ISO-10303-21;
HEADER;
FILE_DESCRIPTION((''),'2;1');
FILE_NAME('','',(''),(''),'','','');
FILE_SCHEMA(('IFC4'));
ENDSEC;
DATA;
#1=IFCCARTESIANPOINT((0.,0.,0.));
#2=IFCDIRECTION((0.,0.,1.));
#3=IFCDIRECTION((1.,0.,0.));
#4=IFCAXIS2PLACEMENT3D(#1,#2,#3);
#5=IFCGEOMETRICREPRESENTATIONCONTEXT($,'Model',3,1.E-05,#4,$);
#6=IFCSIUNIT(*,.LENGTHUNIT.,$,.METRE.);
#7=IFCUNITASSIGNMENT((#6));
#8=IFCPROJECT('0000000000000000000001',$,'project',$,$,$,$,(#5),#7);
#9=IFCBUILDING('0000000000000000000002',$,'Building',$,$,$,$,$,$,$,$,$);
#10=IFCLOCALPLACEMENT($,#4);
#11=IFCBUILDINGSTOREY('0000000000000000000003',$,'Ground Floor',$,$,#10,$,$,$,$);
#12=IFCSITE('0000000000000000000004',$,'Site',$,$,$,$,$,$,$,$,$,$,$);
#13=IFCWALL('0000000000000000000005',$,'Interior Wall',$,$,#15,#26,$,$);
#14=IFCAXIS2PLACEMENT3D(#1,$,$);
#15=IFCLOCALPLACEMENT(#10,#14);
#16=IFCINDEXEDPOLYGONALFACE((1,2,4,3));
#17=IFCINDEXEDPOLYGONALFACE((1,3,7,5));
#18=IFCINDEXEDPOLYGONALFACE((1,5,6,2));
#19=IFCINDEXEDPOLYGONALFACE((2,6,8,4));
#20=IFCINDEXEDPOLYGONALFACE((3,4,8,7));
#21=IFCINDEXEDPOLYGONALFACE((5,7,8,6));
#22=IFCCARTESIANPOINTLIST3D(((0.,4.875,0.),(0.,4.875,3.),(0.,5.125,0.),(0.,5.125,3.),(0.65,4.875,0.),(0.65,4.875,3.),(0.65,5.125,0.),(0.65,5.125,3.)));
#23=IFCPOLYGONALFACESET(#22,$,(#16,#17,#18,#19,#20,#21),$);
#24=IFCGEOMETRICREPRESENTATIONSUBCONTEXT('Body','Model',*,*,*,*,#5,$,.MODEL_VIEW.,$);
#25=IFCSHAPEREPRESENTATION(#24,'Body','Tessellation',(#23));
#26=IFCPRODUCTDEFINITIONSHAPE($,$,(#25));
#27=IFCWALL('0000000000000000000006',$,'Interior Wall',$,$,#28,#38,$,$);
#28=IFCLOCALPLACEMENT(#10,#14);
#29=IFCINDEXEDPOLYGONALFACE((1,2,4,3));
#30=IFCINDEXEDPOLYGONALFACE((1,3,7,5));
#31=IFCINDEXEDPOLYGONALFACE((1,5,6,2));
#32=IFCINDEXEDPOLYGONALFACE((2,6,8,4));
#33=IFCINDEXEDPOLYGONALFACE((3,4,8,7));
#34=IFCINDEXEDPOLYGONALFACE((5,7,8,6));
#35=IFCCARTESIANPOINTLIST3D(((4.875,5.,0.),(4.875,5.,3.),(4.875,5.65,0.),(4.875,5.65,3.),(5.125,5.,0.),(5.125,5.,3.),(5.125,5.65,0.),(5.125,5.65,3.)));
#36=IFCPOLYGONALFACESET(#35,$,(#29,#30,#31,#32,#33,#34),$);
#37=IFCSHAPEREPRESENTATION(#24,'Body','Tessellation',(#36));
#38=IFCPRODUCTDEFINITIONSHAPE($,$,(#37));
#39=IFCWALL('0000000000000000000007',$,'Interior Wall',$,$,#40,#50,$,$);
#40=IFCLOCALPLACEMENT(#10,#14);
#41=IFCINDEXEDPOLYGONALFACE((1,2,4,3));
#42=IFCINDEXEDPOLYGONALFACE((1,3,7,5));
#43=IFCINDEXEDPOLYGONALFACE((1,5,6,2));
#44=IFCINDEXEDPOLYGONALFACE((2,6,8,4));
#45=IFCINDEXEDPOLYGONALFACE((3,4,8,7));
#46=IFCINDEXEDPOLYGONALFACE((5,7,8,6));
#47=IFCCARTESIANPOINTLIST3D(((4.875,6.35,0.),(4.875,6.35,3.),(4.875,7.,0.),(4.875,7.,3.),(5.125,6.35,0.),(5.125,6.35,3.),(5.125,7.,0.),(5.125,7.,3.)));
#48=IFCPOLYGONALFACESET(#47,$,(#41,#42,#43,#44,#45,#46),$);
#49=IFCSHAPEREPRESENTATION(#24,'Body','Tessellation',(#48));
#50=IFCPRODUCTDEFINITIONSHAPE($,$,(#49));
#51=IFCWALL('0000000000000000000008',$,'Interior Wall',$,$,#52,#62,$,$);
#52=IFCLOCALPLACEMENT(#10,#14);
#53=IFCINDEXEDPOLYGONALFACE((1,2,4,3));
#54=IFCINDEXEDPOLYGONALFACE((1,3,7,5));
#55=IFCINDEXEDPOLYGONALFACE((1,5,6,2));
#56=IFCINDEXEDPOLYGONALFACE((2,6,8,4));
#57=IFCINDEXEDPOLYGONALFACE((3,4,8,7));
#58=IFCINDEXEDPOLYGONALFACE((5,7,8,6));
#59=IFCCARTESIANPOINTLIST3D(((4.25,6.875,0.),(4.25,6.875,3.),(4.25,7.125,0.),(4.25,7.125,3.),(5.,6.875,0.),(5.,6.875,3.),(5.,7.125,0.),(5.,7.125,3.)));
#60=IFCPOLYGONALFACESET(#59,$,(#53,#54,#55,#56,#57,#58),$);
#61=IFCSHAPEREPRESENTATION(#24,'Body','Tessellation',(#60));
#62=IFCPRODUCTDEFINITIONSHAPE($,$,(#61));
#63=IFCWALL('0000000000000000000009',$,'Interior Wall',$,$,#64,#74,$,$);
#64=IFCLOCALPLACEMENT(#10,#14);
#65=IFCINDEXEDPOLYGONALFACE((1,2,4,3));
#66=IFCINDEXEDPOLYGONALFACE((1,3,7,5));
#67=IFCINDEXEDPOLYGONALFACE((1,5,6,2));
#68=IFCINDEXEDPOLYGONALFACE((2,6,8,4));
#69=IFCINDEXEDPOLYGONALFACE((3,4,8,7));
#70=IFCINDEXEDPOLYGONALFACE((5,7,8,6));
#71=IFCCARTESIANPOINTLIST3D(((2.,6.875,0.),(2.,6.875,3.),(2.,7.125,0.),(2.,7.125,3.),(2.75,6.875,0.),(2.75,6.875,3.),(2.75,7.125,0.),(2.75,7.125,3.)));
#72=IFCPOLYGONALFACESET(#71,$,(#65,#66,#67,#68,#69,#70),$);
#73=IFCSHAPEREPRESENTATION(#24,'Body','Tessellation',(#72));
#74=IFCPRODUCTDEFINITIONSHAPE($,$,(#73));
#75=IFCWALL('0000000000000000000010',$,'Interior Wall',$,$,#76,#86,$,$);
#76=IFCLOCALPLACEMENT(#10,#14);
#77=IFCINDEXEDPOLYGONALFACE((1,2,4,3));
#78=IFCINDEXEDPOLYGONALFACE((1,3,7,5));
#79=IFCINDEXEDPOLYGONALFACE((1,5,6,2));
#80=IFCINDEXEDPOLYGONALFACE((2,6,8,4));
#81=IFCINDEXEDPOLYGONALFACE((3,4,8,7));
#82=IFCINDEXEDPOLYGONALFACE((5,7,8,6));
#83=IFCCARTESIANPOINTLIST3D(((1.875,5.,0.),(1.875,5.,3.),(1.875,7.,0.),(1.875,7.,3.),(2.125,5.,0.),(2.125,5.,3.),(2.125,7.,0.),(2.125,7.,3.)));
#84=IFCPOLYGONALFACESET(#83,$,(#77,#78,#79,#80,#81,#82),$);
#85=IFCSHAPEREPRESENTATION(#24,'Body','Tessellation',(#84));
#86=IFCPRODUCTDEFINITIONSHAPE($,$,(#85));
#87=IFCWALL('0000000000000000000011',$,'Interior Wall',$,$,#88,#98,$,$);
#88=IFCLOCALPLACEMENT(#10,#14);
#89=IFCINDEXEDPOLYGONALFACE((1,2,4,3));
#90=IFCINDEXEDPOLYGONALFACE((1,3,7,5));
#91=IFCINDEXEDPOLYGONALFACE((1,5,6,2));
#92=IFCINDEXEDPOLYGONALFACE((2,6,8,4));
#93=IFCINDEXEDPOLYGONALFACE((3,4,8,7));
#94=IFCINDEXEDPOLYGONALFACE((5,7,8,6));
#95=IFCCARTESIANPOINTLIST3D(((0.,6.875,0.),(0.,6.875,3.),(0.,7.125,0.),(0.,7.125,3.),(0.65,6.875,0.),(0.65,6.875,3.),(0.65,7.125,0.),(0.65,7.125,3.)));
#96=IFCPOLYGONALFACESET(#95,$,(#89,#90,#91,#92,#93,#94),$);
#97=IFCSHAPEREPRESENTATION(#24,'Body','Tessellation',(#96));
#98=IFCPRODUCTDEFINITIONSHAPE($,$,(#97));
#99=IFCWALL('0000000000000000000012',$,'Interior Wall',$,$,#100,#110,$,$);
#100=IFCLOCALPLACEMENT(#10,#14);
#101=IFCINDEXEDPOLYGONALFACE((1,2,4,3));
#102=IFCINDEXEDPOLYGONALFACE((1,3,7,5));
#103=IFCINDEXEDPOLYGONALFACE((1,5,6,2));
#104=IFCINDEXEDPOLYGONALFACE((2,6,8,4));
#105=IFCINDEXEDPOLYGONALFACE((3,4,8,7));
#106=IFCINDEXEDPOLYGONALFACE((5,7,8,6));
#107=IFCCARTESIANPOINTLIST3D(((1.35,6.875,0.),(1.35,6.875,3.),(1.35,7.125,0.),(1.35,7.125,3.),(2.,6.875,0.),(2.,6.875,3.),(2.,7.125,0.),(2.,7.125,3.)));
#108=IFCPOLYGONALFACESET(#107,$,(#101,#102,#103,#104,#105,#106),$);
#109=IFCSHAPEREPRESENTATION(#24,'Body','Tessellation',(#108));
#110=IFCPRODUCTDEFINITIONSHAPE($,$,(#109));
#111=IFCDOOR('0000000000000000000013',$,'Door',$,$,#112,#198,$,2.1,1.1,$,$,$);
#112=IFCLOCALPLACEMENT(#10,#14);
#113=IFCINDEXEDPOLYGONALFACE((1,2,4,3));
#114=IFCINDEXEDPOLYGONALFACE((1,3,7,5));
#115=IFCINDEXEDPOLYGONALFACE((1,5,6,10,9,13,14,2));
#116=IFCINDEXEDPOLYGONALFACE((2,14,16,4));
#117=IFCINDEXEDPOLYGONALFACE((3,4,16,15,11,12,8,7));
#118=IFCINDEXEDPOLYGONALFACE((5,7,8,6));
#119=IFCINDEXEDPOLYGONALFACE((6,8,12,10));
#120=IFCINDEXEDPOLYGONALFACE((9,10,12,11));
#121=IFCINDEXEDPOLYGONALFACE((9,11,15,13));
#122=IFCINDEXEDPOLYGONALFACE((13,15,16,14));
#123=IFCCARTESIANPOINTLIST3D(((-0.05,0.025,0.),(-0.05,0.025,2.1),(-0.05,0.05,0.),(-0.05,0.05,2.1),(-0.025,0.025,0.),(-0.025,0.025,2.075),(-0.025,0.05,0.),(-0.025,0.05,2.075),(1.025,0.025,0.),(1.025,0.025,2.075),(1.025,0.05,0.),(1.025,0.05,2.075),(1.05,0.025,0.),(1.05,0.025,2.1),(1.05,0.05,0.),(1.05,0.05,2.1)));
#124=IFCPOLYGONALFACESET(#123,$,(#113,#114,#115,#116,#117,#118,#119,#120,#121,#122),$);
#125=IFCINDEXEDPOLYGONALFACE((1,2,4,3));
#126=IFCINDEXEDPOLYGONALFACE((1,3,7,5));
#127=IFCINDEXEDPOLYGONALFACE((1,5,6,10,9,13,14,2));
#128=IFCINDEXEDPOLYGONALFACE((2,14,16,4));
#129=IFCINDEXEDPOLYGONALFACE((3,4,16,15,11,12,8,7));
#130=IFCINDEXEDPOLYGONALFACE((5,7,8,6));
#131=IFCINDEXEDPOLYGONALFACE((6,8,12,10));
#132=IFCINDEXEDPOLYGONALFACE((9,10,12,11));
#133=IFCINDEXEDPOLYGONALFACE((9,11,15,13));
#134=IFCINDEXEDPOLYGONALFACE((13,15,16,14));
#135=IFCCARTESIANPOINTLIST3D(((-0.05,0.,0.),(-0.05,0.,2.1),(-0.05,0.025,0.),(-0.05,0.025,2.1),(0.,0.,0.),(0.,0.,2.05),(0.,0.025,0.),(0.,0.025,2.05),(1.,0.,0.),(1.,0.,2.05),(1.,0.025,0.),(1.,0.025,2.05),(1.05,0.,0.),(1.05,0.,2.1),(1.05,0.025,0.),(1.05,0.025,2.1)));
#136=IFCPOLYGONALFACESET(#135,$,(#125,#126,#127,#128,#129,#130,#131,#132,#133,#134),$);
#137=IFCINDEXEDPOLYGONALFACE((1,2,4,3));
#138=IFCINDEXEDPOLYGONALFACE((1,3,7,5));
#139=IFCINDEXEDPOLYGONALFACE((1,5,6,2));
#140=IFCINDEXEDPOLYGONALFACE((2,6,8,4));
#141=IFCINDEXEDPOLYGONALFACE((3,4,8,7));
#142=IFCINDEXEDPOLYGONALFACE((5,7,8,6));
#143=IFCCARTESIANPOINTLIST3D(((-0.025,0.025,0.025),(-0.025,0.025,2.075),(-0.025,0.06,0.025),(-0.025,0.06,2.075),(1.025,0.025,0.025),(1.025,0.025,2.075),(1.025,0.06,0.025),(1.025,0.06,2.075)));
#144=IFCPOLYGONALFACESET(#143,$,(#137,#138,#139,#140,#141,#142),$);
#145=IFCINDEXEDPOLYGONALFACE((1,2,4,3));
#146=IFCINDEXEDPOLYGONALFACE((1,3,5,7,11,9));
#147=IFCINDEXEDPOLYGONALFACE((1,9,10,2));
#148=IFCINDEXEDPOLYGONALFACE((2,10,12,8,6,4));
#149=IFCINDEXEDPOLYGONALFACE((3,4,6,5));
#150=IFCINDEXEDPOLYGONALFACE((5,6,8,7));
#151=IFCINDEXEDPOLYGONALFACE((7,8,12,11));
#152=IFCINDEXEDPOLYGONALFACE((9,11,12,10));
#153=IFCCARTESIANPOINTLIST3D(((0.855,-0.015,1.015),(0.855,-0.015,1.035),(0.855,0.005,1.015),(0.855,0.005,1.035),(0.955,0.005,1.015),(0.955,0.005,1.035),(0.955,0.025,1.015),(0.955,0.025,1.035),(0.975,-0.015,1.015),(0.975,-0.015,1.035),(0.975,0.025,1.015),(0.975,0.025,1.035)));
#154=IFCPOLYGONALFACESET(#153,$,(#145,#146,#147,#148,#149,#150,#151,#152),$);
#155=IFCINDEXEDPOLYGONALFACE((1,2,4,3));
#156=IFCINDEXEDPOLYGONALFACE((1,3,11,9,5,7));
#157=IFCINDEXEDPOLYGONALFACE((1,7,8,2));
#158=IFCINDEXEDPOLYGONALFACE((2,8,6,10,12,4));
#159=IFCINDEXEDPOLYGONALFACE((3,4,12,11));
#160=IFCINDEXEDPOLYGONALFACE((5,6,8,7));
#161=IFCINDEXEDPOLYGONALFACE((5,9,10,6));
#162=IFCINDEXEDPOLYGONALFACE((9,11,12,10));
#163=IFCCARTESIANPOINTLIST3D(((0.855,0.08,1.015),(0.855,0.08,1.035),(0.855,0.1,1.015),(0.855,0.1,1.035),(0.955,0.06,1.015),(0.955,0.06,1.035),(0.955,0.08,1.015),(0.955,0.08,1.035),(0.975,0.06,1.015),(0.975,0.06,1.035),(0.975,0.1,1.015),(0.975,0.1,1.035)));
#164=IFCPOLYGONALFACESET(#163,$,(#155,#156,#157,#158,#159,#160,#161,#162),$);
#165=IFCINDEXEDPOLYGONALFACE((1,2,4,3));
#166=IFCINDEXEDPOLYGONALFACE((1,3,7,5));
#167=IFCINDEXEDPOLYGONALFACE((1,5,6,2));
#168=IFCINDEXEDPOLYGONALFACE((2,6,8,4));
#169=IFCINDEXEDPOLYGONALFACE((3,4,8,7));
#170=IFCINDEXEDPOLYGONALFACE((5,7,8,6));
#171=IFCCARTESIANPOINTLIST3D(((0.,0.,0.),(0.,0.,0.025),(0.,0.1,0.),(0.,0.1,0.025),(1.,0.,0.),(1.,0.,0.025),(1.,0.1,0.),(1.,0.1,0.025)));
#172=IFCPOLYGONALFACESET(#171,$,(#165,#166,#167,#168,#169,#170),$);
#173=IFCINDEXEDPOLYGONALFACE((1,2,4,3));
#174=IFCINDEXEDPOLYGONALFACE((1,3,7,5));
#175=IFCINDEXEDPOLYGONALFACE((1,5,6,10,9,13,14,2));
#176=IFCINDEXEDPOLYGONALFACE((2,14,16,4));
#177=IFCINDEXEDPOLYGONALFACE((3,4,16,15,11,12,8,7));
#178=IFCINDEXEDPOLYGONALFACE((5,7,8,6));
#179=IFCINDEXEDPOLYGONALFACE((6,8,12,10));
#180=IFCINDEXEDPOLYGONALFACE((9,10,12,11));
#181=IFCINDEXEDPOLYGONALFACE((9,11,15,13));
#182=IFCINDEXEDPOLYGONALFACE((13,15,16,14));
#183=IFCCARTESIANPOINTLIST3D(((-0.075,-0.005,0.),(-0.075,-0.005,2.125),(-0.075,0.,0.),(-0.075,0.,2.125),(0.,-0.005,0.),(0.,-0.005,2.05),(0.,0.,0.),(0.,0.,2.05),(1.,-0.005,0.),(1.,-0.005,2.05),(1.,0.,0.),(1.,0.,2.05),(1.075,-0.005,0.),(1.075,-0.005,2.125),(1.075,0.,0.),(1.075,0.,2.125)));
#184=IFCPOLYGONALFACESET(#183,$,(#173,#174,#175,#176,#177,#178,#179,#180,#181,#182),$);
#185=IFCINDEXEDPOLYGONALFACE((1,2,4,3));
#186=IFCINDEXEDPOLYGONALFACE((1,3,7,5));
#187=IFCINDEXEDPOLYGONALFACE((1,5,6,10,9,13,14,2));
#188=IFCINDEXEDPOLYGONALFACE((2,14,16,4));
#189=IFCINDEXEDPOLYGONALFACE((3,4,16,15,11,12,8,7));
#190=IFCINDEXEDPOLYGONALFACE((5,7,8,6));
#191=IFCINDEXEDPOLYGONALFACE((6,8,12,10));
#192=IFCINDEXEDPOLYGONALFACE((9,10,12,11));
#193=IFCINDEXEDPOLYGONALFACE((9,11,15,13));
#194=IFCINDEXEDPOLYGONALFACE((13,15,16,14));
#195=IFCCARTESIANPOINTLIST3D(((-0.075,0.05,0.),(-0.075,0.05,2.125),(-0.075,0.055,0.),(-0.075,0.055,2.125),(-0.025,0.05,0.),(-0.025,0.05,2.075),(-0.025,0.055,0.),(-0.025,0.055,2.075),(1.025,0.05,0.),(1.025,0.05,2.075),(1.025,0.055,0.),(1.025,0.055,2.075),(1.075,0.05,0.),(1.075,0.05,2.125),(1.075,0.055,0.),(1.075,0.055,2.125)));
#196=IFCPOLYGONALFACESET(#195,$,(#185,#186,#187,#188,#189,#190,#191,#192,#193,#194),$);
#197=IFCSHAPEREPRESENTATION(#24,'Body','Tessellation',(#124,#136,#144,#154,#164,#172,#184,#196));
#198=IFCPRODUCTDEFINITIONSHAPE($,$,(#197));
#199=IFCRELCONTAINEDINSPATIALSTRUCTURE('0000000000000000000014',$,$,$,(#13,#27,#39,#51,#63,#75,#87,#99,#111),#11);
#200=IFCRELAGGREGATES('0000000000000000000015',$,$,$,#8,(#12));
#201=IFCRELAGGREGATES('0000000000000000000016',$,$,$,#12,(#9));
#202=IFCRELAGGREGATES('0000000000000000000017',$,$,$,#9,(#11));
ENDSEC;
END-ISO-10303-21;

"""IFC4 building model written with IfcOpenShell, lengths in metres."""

from ifc_helpers import new_model, si_unit, frame, origin_with_axes, place, context, subcontext, project, spatial, line, indexed_curve, outline, extrude, element, save


model = new_model("IFC4")

# Units and contexts
model_context = context("Model", 3, precision=1e-05, world=origin_with_axes())
body_context = subcontext(model_context, "Body", "Model", "MODEL_VIEW")
ifc_project = project(units=[si_unit("LENGTHUNIT", "METRE")], contexts=[model_context])

# Site, building, storey
site = spatial("IfcSite", under=ifc_project, Name="Site")
building = spatial("IfcBuilding", under=site, Name="Building")
storey_placement = place(None, origin_with_axes())
storey = spatial("IfcBuildingStorey", under=building, at=storey_placement, Name="Ground Floor")

# Walls
for number, where, z_axis, x_axis, name in (
    (1, (0.65, 5.0, 0.0), (0.0, 0.0, 1.0), (-1.0, 0.0, 0.0), "Interior Wall"),
):
    element("IfcWall", number, at=place(storey_placement, frame(where, z_axis=z_axis, x_axis=x_axis)), inside=storey, Name=name, context=body_context, shape_type="SweptSolid", body=[
        extrude(outline(indexed_curve([(0.0, 0.0), (0.0, 0.25), (0.65, 0.25), (0.65, 0.0), (0.0, 0.0)], self_intersect=False)), frame((0.0, -0.125, 0.0), z_axis=(0.0, 0.0, 1.0), x_axis=(1.0, 0.0, 0.0)), (0.0, 0.0, 1.0), 3.0),
    ])
for number, where, z_axis, x_axis, name in (
    (2, (5.0, 5.0, 0.0), (0.0, 0.0, 1.0), (0.0, 1.0, 0.0), "Interior Wall"),
    (3, (5.0, 6.35, 0.0), (0.0, 0.0, 1.0), (0.0, 1.0, 0.0), "Interior Wall"),
):
    element("IfcWall", number, at=place(storey_placement, frame(where, z_axis=z_axis, x_axis=x_axis)), inside=storey, Name=name, context=body_context, shape_type="SweptSolid", body=[
        extrude(outline(indexed_curve([(0.0, 0.0), (0.0, 0.25), (0.65, 0.25), (0.65, 0.0), (0.0, 0.0)], self_intersect=False)), frame((0.0, -0.125, 0.0), z_axis=(0.0, 0.0, 1.0), x_axis=(1.0, 0.0, 0.0)), (0.0, 0.0, 1.0), 3.0),
    ])
for number, where, z_axis, x_axis, name in (
    (4, (5.0, 7.0, 0.0), (0.0, 0.0, 1.0), (-1.0, 0.0, 0.0), "Interior Wall"),
    (5, (2.75, 7.0, 0.0), (0.0, 0.0, 1.0), (-1.0, 0.0, 0.0), "Interior Wall"),
):
    element("IfcWall", number, at=place(storey_placement, frame(where, z_axis=z_axis, x_axis=x_axis)), inside=storey, Name=name, context=body_context, shape_type="SweptSolid", body=[
        extrude(outline(indexed_curve([(0.0, 0.0), (0.0, 0.25), (0.75, 0.25), (0.75, 0.0), (0.0, 0.0)], self_intersect=False)), frame((0.0, -0.125, 0.0), z_axis=(0.0, 0.0, 1.0), x_axis=(1.0, 0.0, 0.0)), (0.0, 0.0, 1.0), 3.0),
    ])
wall_1_placement = place(storey_placement, frame((2.0, 7.0, 0.0), z_axis=(0.0, 0.0, 1.0), x_axis=(0.0, -1.0, 0.0)))
element("IfcWall", 6, at=wall_1_placement, inside=storey, Name="Interior Wall", context=body_context, shape_type="SweptSolid", body=[
    extrude(outline(indexed_curve([(0.0, 0.0), (0.0, 0.25), (2.0, 0.25), (2.0, 0.0), (0.0, 0.0)], self_intersect=False)), frame((0.0, -0.125, 0.0), z_axis=(0.0, 0.0, 1.0), x_axis=(1.0, 0.0, 0.0)), (0.0, 0.0, 1.0), 3.0),
])
wall_2_placement = place(storey_placement, frame((0.0, 7.0, 0.0), z_axis=(0.0, 0.0, 1.0), x_axis=(1.0, 0.0, 0.0)))
element("IfcWall", 7, at=wall_2_placement, inside=storey, Name="Interior Wall", context=body_context, shape_type="SweptSolid", body=[
    extrude(outline(indexed_curve([(0.0, 0.0), (0.0, 0.25), (0.65, 0.25), (0.65, 0.0), (0.0, 0.0)], self_intersect=False)), frame((0.0, -0.125, 0.0), z_axis=(0.0, 0.0, 1.0), x_axis=(1.0, 0.0, 0.0)), (0.0, 0.0, 1.0), 3.0),
])
wall_3_placement = place(storey_placement, frame((1.35, 7.0, 0.0), z_axis=(0.0, 0.0, 1.0), x_axis=(1.0, 0.0, 0.0)))
element("IfcWall", 8, at=wall_3_placement, inside=storey, Name="Interior Wall", context=body_context, shape_type="SweptSolid", body=[
    extrude(outline(indexed_curve([(0.0, 0.0), (0.0, 0.25), (0.65, 0.25), (0.65, 0.0), (0.0, 0.0)], self_intersect=False)), frame((0.0, -0.125, 0.0), z_axis=(0.0, 0.0, 1.0), x_axis=(1.0, 0.0, 0.0)), (0.0, 0.0, 1.0), 3.0),
])

# Door
door_1_placement = place(storey_placement, frame((-0.05, 0.0, 0.0), z_axis=(0.0, 0.0, 1.0), x_axis=(1.0, 0.0, 0.0)))
element("IfcDoor", 9, at=door_1_placement, inside=storey, Name="Door", OverallHeight=2.1, OverallWidth=1.1, context=body_context, shape_type="SweptSolid", body=[
    extrude(outline(indexed_curve([(0.0, 0.0), (0.0, 2.1), (1.1, 2.1), (1.1, 0.0), (1.075, 0.0), (1.075, 2.075), (0.025, 2.075), (0.025, 0.0)], segments=[line(1, 2, 3, 4, 5, 6, 7, 8, 1)])), frame((0.0, 0.025, 0.0), z_axis=(0.0, -1.0, 0.0), x_axis=(1.0, 0.0, 0.0)), (0.0, 0.0, -1.0), 0.025),
    extrude(outline(indexed_curve([(0.0, 0.0), (0.0, 2.1), (1.1, 2.1), (1.1, 0.0), (1.05, 0.0), (1.05, 2.05), (0.05, 2.05), (0.05, 0.0)], segments=[line(1, 2, 3, 4, 5, 6, 7, 8, 1)])), frame((0.0, 0.0, 0.0), z_axis=(0.0, -1.0, 0.0), x_axis=(1.0, 0.0, 0.0)), (0.0, 0.0, -1.0), 0.025),
    extrude(outline(indexed_curve([(0.0, 0.0), (1.05, 0.0), (1.05, 0.035), (0.0, 0.035)], segments=[line(1, 2, 3, 4, 1)])), frame((0.025, 0.025, 0.025), z_axis=(0.0, 0.0, 1.0), x_axis=(1.0, 0.0, 0.0)), (0.0, 0.0, 1.0), 2.05),
    extrude(outline(indexed_curve([(0.0, 0.0), (0.0, -0.04), (-0.12, -0.04), (-0.12, -0.02), (-0.02, -0.02), (-0.02, 0.0)], segments=[line(1, 2, 3, 4, 5, 6, 1)])), frame((1.025, 0.025, 1.015), z_axis=(0.0, 0.0, 1.0), x_axis=(1.0, 0.0, 0.0)), (0.0, 0.0, 1.0), 0.02),
    extrude(outline(indexed_curve([(0.0, 0.0), (0.0, 0.04), (-0.12, 0.04), (-0.12, 0.02), (-0.02, 0.02), (-0.02, 0.0)], segments=[line(1, 2, 3, 4, 5, 6, 1)])), frame((1.025, 0.06, 1.015), z_axis=(0.0, 0.0, 1.0), x_axis=(1.0, 0.0, 0.0)), (0.0, 0.0, 1.0), 0.02),
    extrude(outline(indexed_curve([(0.0, 0.0), (1.0, 0.0), (1.0, 0.1), (0.0, 0.1)], segments=[line(1, 2, 3, 4, 1)])), frame((0.05, 0.0, 0.0), z_axis=(0.0, 0.0, 1.0), x_axis=(1.0, 0.0, 0.0)), (0.0, 0.0, 1.0), 0.025),
    extrude(outline(indexed_curve([(0.0, 0.0), (0.0, 2.125), (1.15, 2.125), (1.15, 0.0), (1.075, 0.0), (1.075, 2.05), (0.075, 2.05), (0.075, 0.0)], segments=[line(1, 2, 3, 4, 5, 6, 7, 8, 1)])), frame((-0.025, -0.005, 0.0), z_axis=(0.0, -1.0, 0.0), x_axis=(1.0, 0.0, 0.0)), (0.0, 0.0, -1.0), 0.005),
    extrude(outline(indexed_curve([(0.0, 0.0), (0.0, 2.125), (1.15, 2.125), (1.15, 0.0), (1.1, 0.0), (1.1, 2.075), (0.05, 2.075), (0.05, 0.0)], segments=[line(1, 2, 3, 4, 5, 6, 7, 8, 1)])), frame((-0.025, 0.05, 0.0), z_axis=(0.0, -1.0, 0.0), x_axis=(1.0, 0.0, 0.0)), (0.0, 0.0, -1.0), 0.005),
])

save(model, "model.ifc")
